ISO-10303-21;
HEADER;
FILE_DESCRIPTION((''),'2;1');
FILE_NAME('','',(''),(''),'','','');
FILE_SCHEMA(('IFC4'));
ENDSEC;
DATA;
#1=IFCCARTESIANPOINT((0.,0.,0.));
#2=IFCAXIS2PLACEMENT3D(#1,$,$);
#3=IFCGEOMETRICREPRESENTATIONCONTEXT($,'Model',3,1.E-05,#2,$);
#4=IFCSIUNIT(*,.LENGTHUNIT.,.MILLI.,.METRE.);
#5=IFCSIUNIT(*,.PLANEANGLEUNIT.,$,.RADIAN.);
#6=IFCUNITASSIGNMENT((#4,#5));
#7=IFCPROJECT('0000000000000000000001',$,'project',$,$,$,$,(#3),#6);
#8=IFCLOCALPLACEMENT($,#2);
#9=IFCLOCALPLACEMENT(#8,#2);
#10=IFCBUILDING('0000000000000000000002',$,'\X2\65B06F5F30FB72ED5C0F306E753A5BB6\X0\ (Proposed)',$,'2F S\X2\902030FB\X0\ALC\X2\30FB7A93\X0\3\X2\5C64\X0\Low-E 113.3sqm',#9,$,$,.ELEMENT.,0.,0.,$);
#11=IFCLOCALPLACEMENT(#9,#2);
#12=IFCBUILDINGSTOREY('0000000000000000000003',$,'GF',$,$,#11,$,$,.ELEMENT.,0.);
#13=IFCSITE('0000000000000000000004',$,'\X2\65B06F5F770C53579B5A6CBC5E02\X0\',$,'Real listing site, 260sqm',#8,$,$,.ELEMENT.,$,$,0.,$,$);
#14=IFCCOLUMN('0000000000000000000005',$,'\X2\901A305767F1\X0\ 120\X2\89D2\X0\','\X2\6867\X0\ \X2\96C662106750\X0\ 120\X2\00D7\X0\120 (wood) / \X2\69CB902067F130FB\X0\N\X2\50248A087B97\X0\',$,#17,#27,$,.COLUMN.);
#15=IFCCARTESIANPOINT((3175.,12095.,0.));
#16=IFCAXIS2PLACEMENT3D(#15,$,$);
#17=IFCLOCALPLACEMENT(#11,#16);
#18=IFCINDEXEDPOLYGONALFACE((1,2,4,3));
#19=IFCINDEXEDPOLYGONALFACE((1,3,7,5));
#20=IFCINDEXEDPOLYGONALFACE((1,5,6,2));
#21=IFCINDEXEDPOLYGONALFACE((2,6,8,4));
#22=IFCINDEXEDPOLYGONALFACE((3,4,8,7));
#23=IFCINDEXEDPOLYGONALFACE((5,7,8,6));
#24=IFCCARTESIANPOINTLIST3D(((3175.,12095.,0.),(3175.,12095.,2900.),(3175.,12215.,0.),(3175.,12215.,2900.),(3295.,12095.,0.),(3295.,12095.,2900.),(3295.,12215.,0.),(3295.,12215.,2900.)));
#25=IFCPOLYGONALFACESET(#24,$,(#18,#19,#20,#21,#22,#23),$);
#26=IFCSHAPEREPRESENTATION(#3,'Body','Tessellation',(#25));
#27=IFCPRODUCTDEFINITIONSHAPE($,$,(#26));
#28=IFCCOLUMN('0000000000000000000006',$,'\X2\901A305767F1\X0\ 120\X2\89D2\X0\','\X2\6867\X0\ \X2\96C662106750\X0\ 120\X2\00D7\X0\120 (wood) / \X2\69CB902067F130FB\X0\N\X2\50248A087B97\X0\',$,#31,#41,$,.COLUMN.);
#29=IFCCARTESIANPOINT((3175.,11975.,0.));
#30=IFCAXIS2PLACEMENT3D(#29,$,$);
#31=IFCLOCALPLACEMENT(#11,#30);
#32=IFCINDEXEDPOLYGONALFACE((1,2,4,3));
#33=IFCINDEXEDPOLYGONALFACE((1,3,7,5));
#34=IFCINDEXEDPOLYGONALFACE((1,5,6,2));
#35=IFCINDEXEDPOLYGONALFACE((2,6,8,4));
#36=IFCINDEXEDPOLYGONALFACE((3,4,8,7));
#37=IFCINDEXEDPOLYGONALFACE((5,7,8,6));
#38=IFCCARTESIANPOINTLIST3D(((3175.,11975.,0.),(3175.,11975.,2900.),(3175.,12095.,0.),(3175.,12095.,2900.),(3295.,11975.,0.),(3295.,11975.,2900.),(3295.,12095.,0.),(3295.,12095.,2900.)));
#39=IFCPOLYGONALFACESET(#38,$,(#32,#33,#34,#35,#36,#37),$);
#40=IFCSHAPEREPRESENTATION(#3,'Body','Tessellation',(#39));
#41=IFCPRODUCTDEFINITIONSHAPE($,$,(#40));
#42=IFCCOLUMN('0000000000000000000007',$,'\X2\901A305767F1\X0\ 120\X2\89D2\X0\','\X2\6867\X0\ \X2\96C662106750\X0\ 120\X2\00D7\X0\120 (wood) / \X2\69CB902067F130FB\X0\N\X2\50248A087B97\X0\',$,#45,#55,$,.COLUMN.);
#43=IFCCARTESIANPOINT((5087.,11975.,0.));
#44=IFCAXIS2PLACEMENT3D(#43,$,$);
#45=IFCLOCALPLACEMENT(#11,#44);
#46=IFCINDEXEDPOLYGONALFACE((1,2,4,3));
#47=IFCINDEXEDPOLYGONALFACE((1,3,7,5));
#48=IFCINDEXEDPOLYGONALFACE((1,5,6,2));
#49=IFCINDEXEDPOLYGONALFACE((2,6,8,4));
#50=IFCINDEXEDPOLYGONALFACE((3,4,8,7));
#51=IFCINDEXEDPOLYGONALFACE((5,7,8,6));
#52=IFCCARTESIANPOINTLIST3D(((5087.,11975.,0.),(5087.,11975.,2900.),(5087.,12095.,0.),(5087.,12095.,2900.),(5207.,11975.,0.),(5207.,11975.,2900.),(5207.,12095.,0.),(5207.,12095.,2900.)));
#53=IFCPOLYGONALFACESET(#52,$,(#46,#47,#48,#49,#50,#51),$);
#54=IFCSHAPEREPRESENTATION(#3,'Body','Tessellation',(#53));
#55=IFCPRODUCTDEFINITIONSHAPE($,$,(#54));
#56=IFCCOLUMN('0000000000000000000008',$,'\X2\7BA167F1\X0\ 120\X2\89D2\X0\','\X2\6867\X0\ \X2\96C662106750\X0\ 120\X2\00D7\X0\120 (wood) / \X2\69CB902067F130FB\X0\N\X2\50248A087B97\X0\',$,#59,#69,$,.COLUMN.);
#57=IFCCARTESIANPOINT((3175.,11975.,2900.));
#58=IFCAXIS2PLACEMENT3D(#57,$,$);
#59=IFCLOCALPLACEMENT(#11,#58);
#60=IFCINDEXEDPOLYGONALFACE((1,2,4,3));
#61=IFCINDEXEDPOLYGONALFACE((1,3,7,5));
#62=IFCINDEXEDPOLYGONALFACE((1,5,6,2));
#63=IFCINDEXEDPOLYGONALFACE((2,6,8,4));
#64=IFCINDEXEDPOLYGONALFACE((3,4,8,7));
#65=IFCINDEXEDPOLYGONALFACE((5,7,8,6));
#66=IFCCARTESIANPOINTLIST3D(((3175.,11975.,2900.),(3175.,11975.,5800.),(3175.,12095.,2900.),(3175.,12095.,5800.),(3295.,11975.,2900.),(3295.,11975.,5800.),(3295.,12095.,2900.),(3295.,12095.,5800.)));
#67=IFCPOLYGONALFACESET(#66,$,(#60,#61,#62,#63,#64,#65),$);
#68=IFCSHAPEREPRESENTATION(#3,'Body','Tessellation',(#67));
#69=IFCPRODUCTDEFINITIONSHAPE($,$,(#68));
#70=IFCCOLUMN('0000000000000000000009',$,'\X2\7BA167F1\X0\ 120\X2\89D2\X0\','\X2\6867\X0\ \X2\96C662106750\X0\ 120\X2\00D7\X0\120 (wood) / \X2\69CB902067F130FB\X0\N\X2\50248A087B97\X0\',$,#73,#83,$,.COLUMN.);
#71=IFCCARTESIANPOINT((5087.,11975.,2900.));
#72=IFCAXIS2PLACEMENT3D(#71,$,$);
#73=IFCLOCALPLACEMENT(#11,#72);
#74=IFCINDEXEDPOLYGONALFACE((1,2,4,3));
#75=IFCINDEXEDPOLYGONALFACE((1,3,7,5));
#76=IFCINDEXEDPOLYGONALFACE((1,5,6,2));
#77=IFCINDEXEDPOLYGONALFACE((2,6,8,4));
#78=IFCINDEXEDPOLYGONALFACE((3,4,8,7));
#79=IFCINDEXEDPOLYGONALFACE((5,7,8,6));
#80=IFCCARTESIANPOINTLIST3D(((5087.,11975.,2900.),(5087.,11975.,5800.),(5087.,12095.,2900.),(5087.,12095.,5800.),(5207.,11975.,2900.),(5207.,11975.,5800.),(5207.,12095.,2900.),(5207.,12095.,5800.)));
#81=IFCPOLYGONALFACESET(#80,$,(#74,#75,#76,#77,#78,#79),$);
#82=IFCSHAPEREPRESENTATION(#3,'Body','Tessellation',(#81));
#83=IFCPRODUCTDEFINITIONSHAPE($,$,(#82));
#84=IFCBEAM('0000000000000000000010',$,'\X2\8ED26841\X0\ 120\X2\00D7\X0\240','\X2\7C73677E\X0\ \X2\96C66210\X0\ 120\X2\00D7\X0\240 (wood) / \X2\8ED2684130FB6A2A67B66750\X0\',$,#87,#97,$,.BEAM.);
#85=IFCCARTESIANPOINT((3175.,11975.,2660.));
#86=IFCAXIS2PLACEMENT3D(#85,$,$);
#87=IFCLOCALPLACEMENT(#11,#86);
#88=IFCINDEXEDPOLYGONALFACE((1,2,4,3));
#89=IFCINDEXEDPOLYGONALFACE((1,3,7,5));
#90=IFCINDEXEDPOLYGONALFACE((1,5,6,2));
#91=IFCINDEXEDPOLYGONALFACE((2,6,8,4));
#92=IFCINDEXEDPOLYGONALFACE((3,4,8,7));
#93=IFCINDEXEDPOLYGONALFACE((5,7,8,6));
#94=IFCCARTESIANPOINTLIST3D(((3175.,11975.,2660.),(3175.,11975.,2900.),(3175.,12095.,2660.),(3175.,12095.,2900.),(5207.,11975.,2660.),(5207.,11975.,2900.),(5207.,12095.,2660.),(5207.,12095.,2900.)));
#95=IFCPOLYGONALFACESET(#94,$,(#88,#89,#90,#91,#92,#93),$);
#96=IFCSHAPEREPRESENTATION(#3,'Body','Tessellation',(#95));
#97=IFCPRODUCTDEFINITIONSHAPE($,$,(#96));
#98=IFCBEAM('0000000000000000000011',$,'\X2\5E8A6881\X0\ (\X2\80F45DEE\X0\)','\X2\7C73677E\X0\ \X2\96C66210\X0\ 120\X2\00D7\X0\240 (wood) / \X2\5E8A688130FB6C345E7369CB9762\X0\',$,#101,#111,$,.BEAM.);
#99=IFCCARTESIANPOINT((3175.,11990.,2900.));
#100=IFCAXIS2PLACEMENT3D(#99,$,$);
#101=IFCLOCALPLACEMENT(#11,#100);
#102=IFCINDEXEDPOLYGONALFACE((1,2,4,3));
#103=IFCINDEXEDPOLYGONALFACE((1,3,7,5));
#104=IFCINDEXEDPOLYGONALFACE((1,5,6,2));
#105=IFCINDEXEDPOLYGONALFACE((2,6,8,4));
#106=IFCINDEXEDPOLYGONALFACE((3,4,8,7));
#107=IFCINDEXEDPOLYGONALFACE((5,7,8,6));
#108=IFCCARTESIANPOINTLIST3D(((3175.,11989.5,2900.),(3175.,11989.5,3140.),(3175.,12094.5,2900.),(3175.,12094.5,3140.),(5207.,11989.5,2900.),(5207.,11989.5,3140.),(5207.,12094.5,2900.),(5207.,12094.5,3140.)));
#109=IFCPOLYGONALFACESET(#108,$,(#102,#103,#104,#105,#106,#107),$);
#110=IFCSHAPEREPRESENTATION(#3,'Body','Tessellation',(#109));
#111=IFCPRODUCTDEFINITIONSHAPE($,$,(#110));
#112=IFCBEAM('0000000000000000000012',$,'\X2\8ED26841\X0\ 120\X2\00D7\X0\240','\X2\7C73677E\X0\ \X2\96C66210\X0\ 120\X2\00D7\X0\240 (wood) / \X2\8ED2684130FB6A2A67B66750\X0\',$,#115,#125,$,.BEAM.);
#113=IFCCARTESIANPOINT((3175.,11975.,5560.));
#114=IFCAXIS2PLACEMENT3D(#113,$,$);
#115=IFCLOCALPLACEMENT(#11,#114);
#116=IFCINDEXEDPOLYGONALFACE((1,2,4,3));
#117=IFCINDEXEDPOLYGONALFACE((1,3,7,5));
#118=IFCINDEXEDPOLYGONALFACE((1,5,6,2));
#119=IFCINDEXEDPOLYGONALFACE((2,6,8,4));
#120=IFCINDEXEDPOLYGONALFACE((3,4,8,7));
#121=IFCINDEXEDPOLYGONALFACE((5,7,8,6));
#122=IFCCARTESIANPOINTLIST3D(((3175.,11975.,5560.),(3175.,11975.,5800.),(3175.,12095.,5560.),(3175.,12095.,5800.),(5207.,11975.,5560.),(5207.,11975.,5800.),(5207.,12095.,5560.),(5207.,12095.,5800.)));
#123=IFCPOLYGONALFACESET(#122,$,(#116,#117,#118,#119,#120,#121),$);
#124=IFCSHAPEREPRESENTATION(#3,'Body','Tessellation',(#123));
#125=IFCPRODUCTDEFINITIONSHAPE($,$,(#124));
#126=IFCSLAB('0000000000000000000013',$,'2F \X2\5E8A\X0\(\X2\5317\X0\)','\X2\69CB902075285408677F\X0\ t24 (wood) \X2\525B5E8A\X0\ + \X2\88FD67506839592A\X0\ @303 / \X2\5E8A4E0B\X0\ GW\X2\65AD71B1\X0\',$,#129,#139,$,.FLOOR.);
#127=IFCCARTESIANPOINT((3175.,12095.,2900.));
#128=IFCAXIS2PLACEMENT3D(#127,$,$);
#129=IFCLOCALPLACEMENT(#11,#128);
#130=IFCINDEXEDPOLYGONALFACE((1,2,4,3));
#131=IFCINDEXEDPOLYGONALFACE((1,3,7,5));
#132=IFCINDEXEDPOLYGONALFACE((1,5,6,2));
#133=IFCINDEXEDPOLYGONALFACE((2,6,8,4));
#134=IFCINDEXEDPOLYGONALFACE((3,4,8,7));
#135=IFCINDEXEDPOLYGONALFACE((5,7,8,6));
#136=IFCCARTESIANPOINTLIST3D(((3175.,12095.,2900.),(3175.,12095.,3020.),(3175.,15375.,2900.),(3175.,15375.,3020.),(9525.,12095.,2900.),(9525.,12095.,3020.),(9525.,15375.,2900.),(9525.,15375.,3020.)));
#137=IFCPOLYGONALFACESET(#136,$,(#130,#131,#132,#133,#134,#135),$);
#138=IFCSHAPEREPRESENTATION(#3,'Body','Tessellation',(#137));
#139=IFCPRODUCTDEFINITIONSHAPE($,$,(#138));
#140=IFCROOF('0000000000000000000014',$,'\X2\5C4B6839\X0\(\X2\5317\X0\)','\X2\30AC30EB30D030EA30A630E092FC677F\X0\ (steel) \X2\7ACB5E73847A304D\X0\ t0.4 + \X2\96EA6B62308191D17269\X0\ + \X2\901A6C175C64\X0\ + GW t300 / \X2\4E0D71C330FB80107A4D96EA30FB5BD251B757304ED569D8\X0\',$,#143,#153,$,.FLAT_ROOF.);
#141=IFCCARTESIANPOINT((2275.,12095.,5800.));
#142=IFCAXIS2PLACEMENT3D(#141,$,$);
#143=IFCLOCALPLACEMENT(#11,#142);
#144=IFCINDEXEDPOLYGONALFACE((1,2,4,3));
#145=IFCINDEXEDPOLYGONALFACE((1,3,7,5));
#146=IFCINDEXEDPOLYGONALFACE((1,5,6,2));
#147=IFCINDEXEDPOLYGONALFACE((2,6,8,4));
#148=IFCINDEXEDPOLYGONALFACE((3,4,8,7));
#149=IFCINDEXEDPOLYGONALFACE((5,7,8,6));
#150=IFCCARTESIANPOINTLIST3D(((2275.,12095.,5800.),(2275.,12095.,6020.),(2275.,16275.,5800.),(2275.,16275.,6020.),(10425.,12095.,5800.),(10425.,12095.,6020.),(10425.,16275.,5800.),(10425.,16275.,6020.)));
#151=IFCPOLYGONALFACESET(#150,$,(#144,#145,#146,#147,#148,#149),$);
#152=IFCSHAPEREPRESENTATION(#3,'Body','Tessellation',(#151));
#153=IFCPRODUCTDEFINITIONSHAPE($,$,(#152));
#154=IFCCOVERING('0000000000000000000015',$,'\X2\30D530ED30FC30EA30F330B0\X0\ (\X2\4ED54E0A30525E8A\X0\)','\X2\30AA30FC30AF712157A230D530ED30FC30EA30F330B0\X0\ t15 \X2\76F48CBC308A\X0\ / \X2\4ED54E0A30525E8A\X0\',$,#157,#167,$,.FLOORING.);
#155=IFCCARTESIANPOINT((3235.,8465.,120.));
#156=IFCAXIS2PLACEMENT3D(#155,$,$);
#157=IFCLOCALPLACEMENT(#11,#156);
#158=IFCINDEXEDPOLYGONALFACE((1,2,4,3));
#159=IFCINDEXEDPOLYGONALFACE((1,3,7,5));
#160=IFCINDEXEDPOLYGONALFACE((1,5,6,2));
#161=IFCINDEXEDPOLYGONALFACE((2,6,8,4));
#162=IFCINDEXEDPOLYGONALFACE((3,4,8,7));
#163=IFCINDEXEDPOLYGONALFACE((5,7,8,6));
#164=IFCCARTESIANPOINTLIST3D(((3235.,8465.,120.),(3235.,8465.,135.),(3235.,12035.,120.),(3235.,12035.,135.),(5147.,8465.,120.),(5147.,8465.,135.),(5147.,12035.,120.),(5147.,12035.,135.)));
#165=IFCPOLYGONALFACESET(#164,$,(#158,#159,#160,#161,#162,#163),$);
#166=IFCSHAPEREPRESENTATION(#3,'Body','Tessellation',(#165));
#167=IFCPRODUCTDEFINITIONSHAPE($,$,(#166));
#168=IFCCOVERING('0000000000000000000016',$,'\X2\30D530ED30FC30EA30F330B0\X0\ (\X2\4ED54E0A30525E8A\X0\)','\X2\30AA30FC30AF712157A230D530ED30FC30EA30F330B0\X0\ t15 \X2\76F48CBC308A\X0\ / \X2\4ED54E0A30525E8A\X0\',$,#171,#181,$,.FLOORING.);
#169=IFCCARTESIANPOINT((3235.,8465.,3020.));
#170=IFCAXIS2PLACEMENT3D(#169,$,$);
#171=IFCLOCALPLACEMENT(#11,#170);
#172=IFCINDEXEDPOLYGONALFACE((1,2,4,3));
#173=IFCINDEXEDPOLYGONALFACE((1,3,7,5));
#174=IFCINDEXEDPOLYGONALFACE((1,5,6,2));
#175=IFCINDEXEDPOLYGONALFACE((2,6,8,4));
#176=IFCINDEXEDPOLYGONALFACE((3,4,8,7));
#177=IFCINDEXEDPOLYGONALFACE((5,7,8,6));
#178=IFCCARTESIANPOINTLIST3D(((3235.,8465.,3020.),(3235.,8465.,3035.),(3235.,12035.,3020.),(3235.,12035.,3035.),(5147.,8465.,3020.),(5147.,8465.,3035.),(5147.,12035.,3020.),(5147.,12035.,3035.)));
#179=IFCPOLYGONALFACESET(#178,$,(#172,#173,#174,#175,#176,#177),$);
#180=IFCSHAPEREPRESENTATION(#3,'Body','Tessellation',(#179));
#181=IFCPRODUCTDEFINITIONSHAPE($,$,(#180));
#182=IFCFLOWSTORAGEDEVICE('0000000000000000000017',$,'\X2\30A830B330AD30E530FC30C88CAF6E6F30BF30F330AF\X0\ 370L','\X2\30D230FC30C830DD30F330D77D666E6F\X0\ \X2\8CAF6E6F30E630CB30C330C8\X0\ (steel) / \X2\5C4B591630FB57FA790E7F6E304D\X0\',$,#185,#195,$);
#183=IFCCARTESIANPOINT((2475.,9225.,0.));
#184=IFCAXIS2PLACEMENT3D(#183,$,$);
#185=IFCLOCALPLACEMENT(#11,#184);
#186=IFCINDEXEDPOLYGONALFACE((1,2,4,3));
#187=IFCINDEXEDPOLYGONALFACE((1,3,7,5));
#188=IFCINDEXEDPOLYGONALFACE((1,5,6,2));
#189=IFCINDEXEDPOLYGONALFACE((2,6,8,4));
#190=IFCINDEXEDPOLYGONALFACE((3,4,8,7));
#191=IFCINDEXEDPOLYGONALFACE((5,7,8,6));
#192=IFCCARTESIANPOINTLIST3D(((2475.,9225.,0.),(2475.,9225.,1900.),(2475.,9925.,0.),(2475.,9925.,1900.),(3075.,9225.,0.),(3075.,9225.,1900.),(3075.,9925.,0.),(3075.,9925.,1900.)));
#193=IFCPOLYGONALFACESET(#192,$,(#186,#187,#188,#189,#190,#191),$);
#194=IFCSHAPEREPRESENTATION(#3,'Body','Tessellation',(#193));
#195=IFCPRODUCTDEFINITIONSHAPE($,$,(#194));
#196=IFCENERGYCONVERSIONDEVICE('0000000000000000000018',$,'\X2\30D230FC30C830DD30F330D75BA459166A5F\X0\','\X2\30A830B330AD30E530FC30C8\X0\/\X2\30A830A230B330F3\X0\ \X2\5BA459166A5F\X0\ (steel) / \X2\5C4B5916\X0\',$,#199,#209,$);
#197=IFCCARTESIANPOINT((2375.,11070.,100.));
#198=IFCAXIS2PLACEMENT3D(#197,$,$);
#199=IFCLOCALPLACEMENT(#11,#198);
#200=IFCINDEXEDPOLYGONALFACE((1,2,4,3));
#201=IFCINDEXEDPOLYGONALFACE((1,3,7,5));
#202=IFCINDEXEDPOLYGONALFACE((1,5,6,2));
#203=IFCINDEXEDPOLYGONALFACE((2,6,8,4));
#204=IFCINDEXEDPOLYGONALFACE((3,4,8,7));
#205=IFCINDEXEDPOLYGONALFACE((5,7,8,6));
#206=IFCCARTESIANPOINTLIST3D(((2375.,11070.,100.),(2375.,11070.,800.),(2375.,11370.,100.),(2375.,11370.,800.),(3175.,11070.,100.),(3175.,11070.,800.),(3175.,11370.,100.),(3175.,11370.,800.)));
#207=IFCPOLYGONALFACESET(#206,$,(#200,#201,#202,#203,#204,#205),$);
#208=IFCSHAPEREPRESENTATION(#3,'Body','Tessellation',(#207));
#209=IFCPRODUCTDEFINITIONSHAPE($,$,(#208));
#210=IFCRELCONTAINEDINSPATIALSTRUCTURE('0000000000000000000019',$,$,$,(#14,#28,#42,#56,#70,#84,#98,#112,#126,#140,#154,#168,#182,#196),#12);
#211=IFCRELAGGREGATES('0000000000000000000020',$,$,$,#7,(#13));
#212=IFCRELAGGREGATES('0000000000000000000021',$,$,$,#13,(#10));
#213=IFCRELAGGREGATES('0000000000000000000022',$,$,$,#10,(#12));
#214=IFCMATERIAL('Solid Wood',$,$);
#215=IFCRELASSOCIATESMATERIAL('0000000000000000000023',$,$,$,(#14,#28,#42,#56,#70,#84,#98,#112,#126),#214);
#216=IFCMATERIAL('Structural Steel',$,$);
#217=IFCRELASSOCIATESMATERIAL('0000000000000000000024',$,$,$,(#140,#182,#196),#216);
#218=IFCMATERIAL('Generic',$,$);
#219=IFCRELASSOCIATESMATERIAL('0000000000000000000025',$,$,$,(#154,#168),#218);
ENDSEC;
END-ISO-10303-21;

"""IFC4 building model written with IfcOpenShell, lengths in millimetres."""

from ifc_helpers import new_model, si_unit, frame, frame_2d, origin, place, context, project, spatial, rectangle, extrude, material, element, save


model = new_model("IFC4")

# Units and contexts
model_context = context("Model", 3, precision=1e-05, world=origin())
ifc_project = project(units=[si_unit("LENGTHUNIT", "METRE", prefix="MILLI"), si_unit("PLANEANGLEUNIT", "RADIAN")], contexts=[model_context])

# Site, building, storey
site_placement = place(None, origin())
site = spatial("IfcSite", under=ifc_project, at=site_placement, Name="新潟県南魚沼市", ObjectType="Real listing site, 260sqm", CompositionType="ELEMENT", RefElevation=0.0)
building_placement = place(site_placement, origin())
building = spatial("IfcBuilding", under=site, at=building_placement, Name="新潟・狭小の町家 (Proposed)", ObjectType="2F S造・ALC・窓3層Low-E 113.3sqm", CompositionType="ELEMENT", ElevationOfRefHeight=0.0, ElevationOfTerrain=0.0)
storey_placement = place(building_placement, origin())
storey = spatial("IfcBuildingStorey", under=building, at=storey_placement, Name="GF", CompositionType="ELEMENT", Elevation=0.0)

# Columns
ifc_material_1 = material(Name="Solid Wood")
column_1_placement = place(storey_placement, frame((3175.0, 12095.0, 0.0)))
element("IfcColumn", 1, at=column_1_placement, inside=storey, material=ifc_material_1, Name="通し柱 120角", Description="桧 集成材 120×120 (wood) / 構造柱・N値計算", PredefinedType="COLUMN", context=model_context, shape_type="SweptSolid", body=[
    extrude(rectangle(XDim=120.0, YDim=120.0, at=frame_2d((60.0, 60.0))), frame((3175.0, 12095.0, 0.0)), (0.0, 0.0, 1.0), 2900.0),
])
column_2_placement = place(storey_placement, frame((3175.0, 11975.0, 0.0)))
element("IfcColumn", 2, at=column_2_placement, inside=storey, material=ifc_material_1, Name="通し柱 120角", Description="桧 集成材 120×120 (wood) / 構造柱・N値計算", PredefinedType="COLUMN", context=model_context, shape_type="SweptSolid", body=[
    extrude(rectangle(XDim=120.0, YDim=120.0, at=frame_2d((60.0, 60.0))), frame((3175.0, 11975.0, 0.0)), (0.0, 0.0, 1.0), 2900.0),
])
column_3_placement = place(storey_placement, frame((5087.0, 11975.0, 0.0)))
element("IfcColumn", 3, at=column_3_placement, inside=storey, material=ifc_material_1, Name="通し柱 120角", Description="桧 集成材 120×120 (wood) / 構造柱・N値計算", PredefinedType="COLUMN", context=model_context, shape_type="SweptSolid", body=[
    extrude(rectangle(XDim=120.0, YDim=120.0, at=frame_2d((60.0, 60.0))), frame((5087.0, 11975.0, 0.0)), (0.0, 0.0, 1.0), 2900.0),
])
column_4_placement = place(storey_placement, frame((3175.0, 11975.0, 2900.0)))
element("IfcColumn", 4, at=column_4_placement, inside=storey, material=ifc_material_1, Name="管柱 120角", Description="桧 集成材 120×120 (wood) / 構造柱・N値計算", PredefinedType="COLUMN", context=model_context, shape_type="SweptSolid", body=[
    extrude(rectangle(XDim=120.0, YDim=120.0, at=frame_2d((60.0, 60.0))), frame((3175.0, 11975.0, 2900.0)), (0.0, 0.0, 1.0), 2900.0),
])
column_5_placement = place(storey_placement, frame((5087.0, 11975.0, 2900.0)))
element("IfcColumn", 5, at=column_5_placement, inside=storey, material=ifc_material_1, Name="管柱 120角", Description="桧 集成材 120×120 (wood) / 構造柱・N値計算", PredefinedType="COLUMN", context=model_context, shape_type="SweptSolid", body=[
    extrude(rectangle(XDim=120.0, YDim=120.0, at=frame_2d((60.0, 60.0))), frame((5087.0, 11975.0, 2900.0)), (0.0, 0.0, 1.0), 2900.0),
])

# Beams
beam_1_placement = place(storey_placement, frame((3175.0, 11975.0, 2660.0)))
element("IfcBeam", 6, at=beam_1_placement, inside=storey, material=ifc_material_1, Name="軒桁 120×240", Description="米松 集成 120×240 (wood) / 軒桁・横架材", PredefinedType="BEAM", context=model_context, shape_type="SweptSolid", body=[
    extrude(rectangle(XDim=2032.0, YDim=120.0, at=frame_2d((1016.0, 60.0))), frame((3175.0, 11975.0, 2660.0)), (0.0, 0.0, 1.0), 240.0),
])
beam_2_placement = place(storey_placement, frame((3175.0, 11990.0, 2900.0)))
element("IfcBeam", 7, at=beam_2_placement, inside=storey, material=ifc_material_1, Name="床梁 (胴差)", Description="米松 集成 120×240 (wood) / 床梁・水平構面", PredefinedType="BEAM", context=model_context, shape_type="SweptSolid", body=[
    extrude(rectangle(XDim=2032.0, YDim=105.0, at=frame_2d((1016.0, 52.0))), frame((3175.0, 11990.0, 2900.0)), (0.0, 0.0, 1.0), 240.0),
])
beam_3_placement = place(storey_placement, frame((3175.0, 11975.0, 5560.0)))
element("IfcBeam", 8, at=beam_3_placement, inside=storey, material=ifc_material_1, Name="軒桁 120×240", Description="米松 集成 120×240 (wood) / 軒桁・横架材", PredefinedType="BEAM", context=model_context, shape_type="SweptSolid", body=[
    extrude(rectangle(XDim=2032.0, YDim=120.0, at=frame_2d((1016.0, 60.0))), frame((3175.0, 11975.0, 5560.0)), (0.0, 0.0, 1.0), 240.0),
])

# Slab
slab_1_placement = place(storey_placement, frame((3175.0, 12095.0, 2900.0)))
element("IfcSlab", 9, at=slab_1_placement, inside=storey, material=ifc_material_1, Name="2F 床(北)", Description="構造用合板 t24 (wood) 剛床 + 製材根太 @303 / 床下 GW断熱", PredefinedType="FLOOR", context=model_context, shape_type="SweptSolid", body=[
    extrude(rectangle(XDim=6350.0, YDim=3280.0, at=frame_2d((3175.0, 1640.0))), frame((3175.0, 12095.0, 2900.0)), (0.0, 0.0, 1.0), 120.0),
])

# Roof
ifc_material_2 = material(Name="Structural Steel")
for number, where, name in (
    (10, (2275.0, 12095.0, 5800.0), "屋根(北)"),
):
    element("IfcRoof", number, at=place(storey_placement, frame(where)), inside=storey, material=ifc_material_2, Name=name, Description="ガルバリウム鋼板 (steel) 立平葺き t0.4 + 雪止め金物 + 通気層 + GW t300 / 不燃・耐積雪・寒冷地仕様", PredefinedType="FLAT_ROOF", context=model_context, shape_type="SweptSolid", body=[
        extrude(rectangle(XDim=8150.0, YDim=4180.0, at=frame_2d((4075.0, 2090.0))), frame((2275.0, 12095.0, 5800.0)), (0.0, 0.0, 1.0), 220.0),
    ])

# Coverings
ifc_material_3 = material(Name="Generic")
covering_1_placement = place(storey_placement, frame((3235.0, 8465.0, 120.0)))
element("IfcCovering", 11, at=covering_1_placement, inside=storey, material=ifc_material_3, Name="フローリング (仕上げ床)", Description="オーク無垢フローリング t15 直貼り / 仕上げ床", PredefinedType="FLOORING", context=model_context, shape_type="SweptSolid", body=[
    extrude(rectangle(XDim=1912.0, YDim=3570.0, at=frame_2d((956.0, 1785.0))), frame((3235.0, 8465.0, 120.0)), (0.0, 0.0, 1.0), 15.0),
])
covering_2_placement = place(storey_placement, frame((3235.0, 8465.0, 3020.0)))
element("IfcCovering", 12, at=covering_2_placement, inside=storey, material=ifc_material_3, Name="フローリング (仕上げ床)", Description="オーク無垢フローリング t15 直貼り / 仕上げ床", PredefinedType="FLOORING", context=model_context, shape_type="SweptSolid", body=[
    extrude(rectangle(XDim=1912.0, YDim=3570.0, at=frame_2d((956.0, 1785.0))), frame((3235.0, 8465.0, 3020.0)), (0.0, 0.0, 1.0), 15.0),
])

# Flow storage device
flow_storage_device_placement = place(storey_placement, frame((2475.0, 9225.0, 0.0)))
element("IfcFlowStorageDevice", 13, at=flow_storage_device_placement, inside=storey, material=ifc_material_2, Name="エコキュート貯湯タンク 370L", Description="ヒートポンプ給湯 貯湯ユニット (steel) / 屋外・基礎置き", context=model_context, shape_type="SweptSolid", body=[
    extrude(rectangle(XDim=600.0, YDim=700.0, at=frame_2d((300.0, 350.0))), frame((2475.0, 9225.0, 0.0)), (0.0, 0.0, 1.0), 1900.0),
])

# Energy conversion device
energy_conversion_device_placement = place(storey_placement, frame((2375.0, 11070.0, 100.0)))
element("IfcEnergyConversionDevice", 14, at=energy_conversion_device_placement, inside=storey, material=ifc_material_2, Name="ヒートポンプ室外機", Description="エコキュート/エアコン 室外機 (steel) / 屋外", context=model_context, shape_type="SweptSolid", body=[
    extrude(rectangle(XDim=800.0, YDim=300.0, at=frame_2d((400.0, 150.0))), frame((2375.0, 11070.0, 100.0)), (0.0, 0.0, 1.0), 700.0),
])

save(model, "model.ifc")
